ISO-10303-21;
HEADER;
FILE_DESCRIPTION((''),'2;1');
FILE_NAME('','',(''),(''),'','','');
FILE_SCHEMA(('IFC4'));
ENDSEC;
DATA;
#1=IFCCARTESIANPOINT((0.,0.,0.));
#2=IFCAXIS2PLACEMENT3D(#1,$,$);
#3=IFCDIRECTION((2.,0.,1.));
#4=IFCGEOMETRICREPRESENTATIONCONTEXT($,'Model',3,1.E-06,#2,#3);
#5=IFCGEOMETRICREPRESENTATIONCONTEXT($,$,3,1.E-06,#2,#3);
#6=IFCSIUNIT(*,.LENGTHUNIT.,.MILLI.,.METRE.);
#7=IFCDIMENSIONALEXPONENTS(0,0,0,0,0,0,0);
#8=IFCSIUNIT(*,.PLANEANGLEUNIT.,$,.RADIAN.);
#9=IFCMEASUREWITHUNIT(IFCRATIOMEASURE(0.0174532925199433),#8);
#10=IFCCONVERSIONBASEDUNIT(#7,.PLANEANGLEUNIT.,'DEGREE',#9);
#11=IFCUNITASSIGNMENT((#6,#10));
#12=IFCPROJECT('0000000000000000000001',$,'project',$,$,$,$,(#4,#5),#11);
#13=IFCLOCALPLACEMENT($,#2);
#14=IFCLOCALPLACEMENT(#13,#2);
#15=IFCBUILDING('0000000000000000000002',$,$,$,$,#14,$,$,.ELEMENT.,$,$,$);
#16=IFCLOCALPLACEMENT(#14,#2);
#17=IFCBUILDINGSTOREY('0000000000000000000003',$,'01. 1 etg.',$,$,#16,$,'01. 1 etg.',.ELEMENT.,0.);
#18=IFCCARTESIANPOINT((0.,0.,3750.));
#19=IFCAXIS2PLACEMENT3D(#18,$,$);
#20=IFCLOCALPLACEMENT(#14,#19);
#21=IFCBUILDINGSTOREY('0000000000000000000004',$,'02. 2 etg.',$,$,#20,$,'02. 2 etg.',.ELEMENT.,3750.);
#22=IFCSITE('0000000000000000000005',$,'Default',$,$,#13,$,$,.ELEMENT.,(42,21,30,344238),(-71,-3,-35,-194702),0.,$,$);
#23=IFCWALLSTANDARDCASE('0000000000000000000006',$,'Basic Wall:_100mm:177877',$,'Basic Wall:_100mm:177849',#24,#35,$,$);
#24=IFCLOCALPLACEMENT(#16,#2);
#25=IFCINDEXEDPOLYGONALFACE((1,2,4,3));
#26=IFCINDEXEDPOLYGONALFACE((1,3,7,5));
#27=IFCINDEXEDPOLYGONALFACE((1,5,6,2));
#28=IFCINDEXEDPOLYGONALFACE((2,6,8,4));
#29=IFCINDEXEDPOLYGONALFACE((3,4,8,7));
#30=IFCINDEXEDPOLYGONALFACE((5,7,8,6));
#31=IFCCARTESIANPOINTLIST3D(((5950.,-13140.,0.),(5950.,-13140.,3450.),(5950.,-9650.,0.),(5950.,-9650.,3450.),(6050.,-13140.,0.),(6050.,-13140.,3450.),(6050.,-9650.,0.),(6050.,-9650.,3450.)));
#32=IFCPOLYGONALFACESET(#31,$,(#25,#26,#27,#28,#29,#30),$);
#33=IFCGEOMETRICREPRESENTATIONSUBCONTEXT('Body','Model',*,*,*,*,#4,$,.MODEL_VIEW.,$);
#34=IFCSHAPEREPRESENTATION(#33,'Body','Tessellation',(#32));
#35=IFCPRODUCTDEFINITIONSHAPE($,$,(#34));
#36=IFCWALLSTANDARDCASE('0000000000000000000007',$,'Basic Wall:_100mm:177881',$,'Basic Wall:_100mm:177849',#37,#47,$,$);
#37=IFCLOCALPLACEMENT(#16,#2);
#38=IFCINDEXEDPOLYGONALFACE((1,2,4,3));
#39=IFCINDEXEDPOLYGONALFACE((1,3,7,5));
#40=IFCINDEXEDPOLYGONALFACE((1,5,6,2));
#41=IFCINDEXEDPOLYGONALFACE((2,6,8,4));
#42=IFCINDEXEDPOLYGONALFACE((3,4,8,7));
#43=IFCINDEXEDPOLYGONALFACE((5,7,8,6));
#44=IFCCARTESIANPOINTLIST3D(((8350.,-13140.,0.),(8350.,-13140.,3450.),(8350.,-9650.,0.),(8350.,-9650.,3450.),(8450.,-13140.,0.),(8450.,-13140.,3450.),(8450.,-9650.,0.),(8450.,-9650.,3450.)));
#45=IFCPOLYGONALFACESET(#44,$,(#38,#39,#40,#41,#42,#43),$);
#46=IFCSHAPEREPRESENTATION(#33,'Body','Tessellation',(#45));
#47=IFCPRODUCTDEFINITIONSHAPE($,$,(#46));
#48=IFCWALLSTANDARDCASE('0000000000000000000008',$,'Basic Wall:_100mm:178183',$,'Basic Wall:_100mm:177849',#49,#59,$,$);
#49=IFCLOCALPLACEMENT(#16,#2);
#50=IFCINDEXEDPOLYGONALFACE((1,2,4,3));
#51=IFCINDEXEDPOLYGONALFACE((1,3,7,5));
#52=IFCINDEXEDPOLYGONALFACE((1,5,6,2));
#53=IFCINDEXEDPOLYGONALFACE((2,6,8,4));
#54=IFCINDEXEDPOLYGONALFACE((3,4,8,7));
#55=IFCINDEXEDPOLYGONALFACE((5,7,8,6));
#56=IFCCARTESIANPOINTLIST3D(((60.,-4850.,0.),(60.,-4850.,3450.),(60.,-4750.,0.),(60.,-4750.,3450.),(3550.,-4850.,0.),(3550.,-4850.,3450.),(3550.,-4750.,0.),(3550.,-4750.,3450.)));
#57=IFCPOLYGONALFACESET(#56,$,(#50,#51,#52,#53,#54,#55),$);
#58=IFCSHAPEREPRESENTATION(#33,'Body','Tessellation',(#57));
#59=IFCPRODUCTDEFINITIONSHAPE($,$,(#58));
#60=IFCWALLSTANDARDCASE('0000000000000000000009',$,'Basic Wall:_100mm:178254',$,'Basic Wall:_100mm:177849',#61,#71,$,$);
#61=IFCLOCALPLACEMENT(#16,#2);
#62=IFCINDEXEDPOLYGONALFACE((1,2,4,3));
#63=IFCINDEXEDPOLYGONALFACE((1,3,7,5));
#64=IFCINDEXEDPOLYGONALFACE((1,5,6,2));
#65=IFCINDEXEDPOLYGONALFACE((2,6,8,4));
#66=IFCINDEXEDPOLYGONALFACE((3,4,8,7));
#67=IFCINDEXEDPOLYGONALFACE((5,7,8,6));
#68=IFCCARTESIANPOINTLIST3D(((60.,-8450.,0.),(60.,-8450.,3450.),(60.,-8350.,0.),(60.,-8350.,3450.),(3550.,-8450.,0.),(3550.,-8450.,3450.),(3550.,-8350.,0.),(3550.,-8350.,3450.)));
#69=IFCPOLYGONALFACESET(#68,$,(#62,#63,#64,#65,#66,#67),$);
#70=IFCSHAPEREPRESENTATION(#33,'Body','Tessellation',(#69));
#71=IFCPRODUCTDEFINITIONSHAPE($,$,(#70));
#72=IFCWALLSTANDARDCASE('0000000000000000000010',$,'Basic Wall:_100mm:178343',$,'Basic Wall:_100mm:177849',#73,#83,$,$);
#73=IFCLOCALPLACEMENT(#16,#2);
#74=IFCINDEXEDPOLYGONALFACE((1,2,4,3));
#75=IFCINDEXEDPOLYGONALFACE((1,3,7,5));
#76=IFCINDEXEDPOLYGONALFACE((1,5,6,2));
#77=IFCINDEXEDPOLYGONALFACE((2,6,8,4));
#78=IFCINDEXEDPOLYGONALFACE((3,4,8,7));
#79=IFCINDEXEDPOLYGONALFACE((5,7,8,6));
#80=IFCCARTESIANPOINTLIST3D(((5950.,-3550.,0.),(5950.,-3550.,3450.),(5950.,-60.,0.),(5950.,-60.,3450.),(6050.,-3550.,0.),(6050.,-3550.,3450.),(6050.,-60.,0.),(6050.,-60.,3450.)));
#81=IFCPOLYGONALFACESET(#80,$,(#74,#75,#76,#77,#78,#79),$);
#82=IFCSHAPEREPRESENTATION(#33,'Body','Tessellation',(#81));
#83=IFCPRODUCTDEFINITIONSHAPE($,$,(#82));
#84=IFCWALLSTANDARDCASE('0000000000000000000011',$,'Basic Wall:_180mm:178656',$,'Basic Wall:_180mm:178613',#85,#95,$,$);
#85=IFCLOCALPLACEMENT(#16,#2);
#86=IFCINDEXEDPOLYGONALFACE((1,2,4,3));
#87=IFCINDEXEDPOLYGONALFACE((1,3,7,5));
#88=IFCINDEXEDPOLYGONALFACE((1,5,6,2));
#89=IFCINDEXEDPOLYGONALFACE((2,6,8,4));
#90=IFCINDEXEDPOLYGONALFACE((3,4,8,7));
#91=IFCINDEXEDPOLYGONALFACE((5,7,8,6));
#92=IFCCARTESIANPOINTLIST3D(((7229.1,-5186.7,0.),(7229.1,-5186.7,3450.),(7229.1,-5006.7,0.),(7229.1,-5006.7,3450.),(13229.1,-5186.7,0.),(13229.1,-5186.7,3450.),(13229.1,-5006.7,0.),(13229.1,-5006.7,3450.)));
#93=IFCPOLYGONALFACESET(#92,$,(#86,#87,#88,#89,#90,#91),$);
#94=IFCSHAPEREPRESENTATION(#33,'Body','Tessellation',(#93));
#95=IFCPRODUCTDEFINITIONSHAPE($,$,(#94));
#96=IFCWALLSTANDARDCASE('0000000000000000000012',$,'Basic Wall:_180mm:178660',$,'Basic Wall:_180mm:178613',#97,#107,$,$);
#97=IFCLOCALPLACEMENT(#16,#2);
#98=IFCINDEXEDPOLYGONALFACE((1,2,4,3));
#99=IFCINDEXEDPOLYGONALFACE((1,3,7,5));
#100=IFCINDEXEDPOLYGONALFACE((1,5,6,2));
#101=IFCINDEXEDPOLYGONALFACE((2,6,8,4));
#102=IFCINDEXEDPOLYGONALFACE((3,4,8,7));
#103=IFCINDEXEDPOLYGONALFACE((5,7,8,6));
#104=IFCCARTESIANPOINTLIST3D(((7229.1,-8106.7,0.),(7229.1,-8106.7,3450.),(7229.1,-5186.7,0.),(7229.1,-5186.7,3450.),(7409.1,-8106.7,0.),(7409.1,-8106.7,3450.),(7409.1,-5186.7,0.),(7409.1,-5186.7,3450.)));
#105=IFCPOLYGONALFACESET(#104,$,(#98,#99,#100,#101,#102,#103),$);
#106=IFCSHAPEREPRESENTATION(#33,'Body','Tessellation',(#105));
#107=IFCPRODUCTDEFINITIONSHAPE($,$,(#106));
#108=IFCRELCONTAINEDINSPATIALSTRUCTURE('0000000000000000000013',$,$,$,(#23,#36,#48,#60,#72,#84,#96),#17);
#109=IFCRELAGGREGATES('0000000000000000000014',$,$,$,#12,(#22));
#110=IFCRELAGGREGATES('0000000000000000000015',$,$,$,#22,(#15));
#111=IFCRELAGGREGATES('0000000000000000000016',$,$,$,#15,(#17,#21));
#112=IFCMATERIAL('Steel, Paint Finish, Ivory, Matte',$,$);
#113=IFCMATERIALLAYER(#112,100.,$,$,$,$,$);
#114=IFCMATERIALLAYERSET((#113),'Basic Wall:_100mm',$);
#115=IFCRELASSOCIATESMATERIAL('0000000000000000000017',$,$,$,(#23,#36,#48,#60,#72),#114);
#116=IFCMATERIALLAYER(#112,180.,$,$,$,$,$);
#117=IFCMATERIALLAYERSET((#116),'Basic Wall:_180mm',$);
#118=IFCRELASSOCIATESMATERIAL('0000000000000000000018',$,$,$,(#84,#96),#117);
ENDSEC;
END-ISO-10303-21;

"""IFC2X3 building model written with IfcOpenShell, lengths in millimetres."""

from ifc_helpers import new_model, entity, si_unit, converted_unit, direction, frame, frame_2d, origin, place, context, subcontext, project, spatial, polyline, rectangle, extrude, clip, bounded_halfspace, material, layer, layer_set, layer_usage, element, save


model = new_model("IFC2X3")

# Units and contexts
model_context = context("Model", 3, precision=1e-06, world=origin(), true_north=direction((2.0, 0.0, 1.0)))
context_of_model = context(None, 3, precision=1e-06, world=origin(), true_north=direction((2.0, 0.0, 1.0)))
body_context = subcontext(model_context, "Body", "Model", "MODEL_VIEW")
ifc_project = project(units=[si_unit("LENGTHUNIT", "METRE", prefix="MILLI"), converted_unit("PLANEANGLEUNIT", "DEGREE", entity("IfcRatioMeasure", 0.0174532925199433), si_unit("PLANEANGLEUNIT", "RADIAN"), dimensions=[0, 0, 0, 0, 0, 0, 0])], contexts=[model_context, context_of_model])

# Site, building, storey
site_placement = place(None, origin())
site = spatial("IfcSite", under=ifc_project, at=site_placement, Name="Default", CompositionType="ELEMENT", RefLatitude=(42, 21, 30, 344238), RefLongitude=(-71, -3, -35, -194702), RefElevation=0.0)
building_placement = place(site_placement, origin())
building = spatial("IfcBuilding", under=site, at=building_placement, CompositionType="ELEMENT")
storey_1_placement = place(building_placement, origin())
storey_1 = spatial("IfcBuildingStorey", under=building, at=storey_1_placement, Name="01. 1 etg.", LongName="01. 1 etg.", CompositionType="ELEMENT", Elevation=0.0)

# Shared definitions
ifc_material_1 = material(Name="Steel, Paint Finish, Ivory, Matte")
ifc_layer_1 = layer(ifc_material_1, 100.0)
ifc_layer_set_1 = layer_set([ifc_layer_1], Name="Basic Wall:_100mm")

# Walls
ifc_layer_usage_1 = layer_usage(ifc_layer_set_1, "AXIS2", "NEGATIVE", 50.0)
wall_1_placement = place(storey_1_placement, frame((6000.0, -13140.0, 0.0), z_axis=(0.0, 0.0, 1.0), x_axis=(0.0, 1.0, 0.0)))
element("IfcWallStandardCase", 1, at=wall_1_placement, inside=storey_1, material=ifc_layer_usage_1, Name="Basic Wall:_100mm:177877", ObjectType="Basic Wall:_100mm:177849", context=body_context, shape_type="Clipping", body=[
    clip(extrude(rectangle(XDim=3490.0, YDim=100.0, at=frame_2d((1745.0, 0.0), x_axis=(-1.0, 0.0))), origin(), (0.0, 0.0, 1.0), 3450.0), bounded_halfspace(frame((0.0, -50.0, 3450.0), z_axis=(0.0, 0.0, -1.0), x_axis=(-1.0, 0.0, 0.0)), True, frame((0.0, -50.0, 3450.0)), polyline([(0.0, 0.0), (3490.0, 0.0), (3490.0, 100.0), (0.0, 100.0), (0.0, 0.0)]))),
])
ifc_layer_usage_2 = layer_usage(ifc_layer_set_1, "AXIS2", "NEGATIVE", 50.0)
wall_2_placement = place(storey_1_placement, frame((8400.0, -13140.0, 0.0), z_axis=(0.0, 0.0, 1.0), x_axis=(0.0, 1.0, 0.0)))
element("IfcWallStandardCase", 2, at=wall_2_placement, inside=storey_1, material=ifc_layer_usage_2, Name="Basic Wall:_100mm:177881", ObjectType="Basic Wall:_100mm:177849", context=body_context, shape_type="Clipping", body=[
    clip(extrude(rectangle(XDim=3490.0, YDim=100.0, at=frame_2d((1745.0, 0.0), x_axis=(-1.0, 0.0))), origin(), (0.0, 0.0, 1.0), 3450.0), bounded_halfspace(frame((0.0, -50.0, 3450.0), z_axis=(0.0, 0.0, -1.0), x_axis=(-1.0, 0.0, 0.0)), True, frame((0.0, -50.0, 3450.0)), polyline([(0.0, 0.0), (3490.0, 0.0), (3490.0, 100.0), (0.0, 100.0), (0.0, 0.0)]))),
])
ifc_layer_usage_3 = layer_usage(ifc_layer_set_1, "AXIS2", "NEGATIVE", 50.0)
wall_3_placement = place(storey_1_placement, frame((3550.0, -4800.0, 0.0), z_axis=(0.0, 0.0, 1.0), x_axis=(-1.0, 0.0, 0.0)))
element("IfcWallStandardCase", 3, at=wall_3_placement, inside=storey_1, material=ifc_layer_usage_3, Name="Basic Wall:_100mm:178183", ObjectType="Basic Wall:_100mm:177849", context=body_context, shape_type="Clipping", body=[
    clip(extrude(rectangle(XDim=3490.0, YDim=100.0, at=frame_2d((1745.0, 0.0), x_axis=(-1.0, 0.0))), origin(), (0.0, 0.0, 1.0), 3450.0), bounded_halfspace(frame((0.0, -50.0, 3450.0), z_axis=(0.0, 0.0, -1.0), x_axis=(0.0, 1.0, 0.0)), True, frame((0.0, -50.0, 3450.0)), polyline([(0.0, 0.0), (3490.0, 0.0), (3490.0, 100.0), (0.0, 100.0), (0.0, 0.0)]))),
])
ifc_layer_usage_4 = layer_usage(ifc_layer_set_1, "AXIS2", "NEGATIVE", 50.0)
wall_4_placement = place(storey_1_placement, frame((3550.0, -8400.0, 0.0), z_axis=(0.0, 0.0, 1.0), x_axis=(-1.0, 0.0, 0.0)))
element("IfcWallStandardCase", 4, at=wall_4_placement, inside=storey_1, material=ifc_layer_usage_4, Name="Basic Wall:_100mm:178254", ObjectType="Basic Wall:_100mm:177849", context=body_context, shape_type="Clipping", body=[
    clip(extrude(rectangle(XDim=3490.0, YDim=100.0, at=frame_2d((1745.0, 0.0), x_axis=(-1.0, 0.0))), origin(), (0.0, 0.0, 1.0), 3450.0), bounded_halfspace(frame((0.0, -50.0, 3450.0), z_axis=(0.0, 0.0, -1.0), x_axis=(0.0, 1.0, 0.0)), True, frame((0.0, -50.0, 3450.0)), polyline([(0.0, 0.0), (3490.0, 0.0), (3490.0, 100.0), (0.0, 100.0), (0.0, 0.0)]))),
])
ifc_layer_usage_5 = layer_usage(ifc_layer_set_1, "AXIS2", "NEGATIVE", 50.0)
wall_5_placement = place(storey_1_placement, frame((6000.0, -3550.0, 0.0), z_axis=(0.0, 0.0, 1.0), x_axis=(0.0, 1.0, 0.0)))
element("IfcWallStandardCase", 5, at=wall_5_placement, inside=storey_1, material=ifc_layer_usage_5, Name="Basic Wall:_100mm:178343", ObjectType="Basic Wall:_100mm:177849", context=body_context, shape_type="Clipping", body=[
    clip(extrude(rectangle(XDim=3490.0, YDim=100.0, at=frame_2d((1745.0, 0.0), x_axis=(-1.0, 0.0))), origin(), (0.0, 0.0, 1.0), 3450.0), bounded_halfspace(frame((0.0, -50.0, 3450.0), z_axis=(0.0, 0.0, -1.0), x_axis=(-1.0, 0.0, 0.0)), True, frame((0.0, -50.0, 3450.0)), polyline([(0.0, 0.0), (3490.0, 0.0), (3490.0, 100.0), (0.0, 100.0), (0.0, 0.0)]))),
])
ifc_layer_2 = layer(ifc_material_1, 180.0)
ifc_layer_set_2 = layer_set([ifc_layer_2], Name="Basic Wall:_180mm")
ifc_layer_usage_6 = layer_usage(ifc_layer_set_2, "AXIS2", "NEGATIVE", 90.0)
wall_6_placement = place(storey_1_placement, frame((7229.1, -5096.7, 0.0)))
element("IfcWallStandardCase", 6, at=wall_6_placement, inside=storey_1, material=ifc_layer_usage_6, Name="Basic Wall:_180mm:178656", ObjectType="Basic Wall:_180mm:178613", context=body_context, shape_type="Clipping", body=[
    clip(extrude(rectangle(XDim=6000.0, YDim=180.0, at=frame_2d((3000.0, 0.0), x_axis=(-1.0, 0.0))), origin(), (0.0, 0.0, 1.0), 3450.0), bounded_halfspace(frame((0.0, -90.0, 3450.0), z_axis=(0.0, 0.0, -1.0), x_axis=(0.0, -1.0, 0.0)), True, frame((0.0, -90.0, 3450.0)), polyline([(0.0, 0.0), (180.0, 0.0), (2400.0, 0.0), (2500.0, 0.0), (4022.0, 0.0), (4122.0, 0.0), (5820.0, 0.0), (6000.0, 0.0), (6000.0, 180.0), (0.0, 180.0), (0.0, 0.0)]))),
])
ifc_layer_usage_7 = layer_usage(ifc_layer_set_2, "AXIS2", "NEGATIVE", 90.0)
wall_7_placement = place(storey_1_placement, frame((7319.1, -8106.7, 0.0), z_axis=(0.0, 0.0, 1.0), x_axis=(0.0, 1.0, 0.0)))
element("IfcWallStandardCase", 7, at=wall_7_placement, inside=storey_1, material=ifc_layer_usage_7, Name="Basic Wall:_180mm:178660", ObjectType="Basic Wall:_180mm:178613", context=body_context, shape_type="Clipping", body=[
    clip(extrude(rectangle(XDim=2920.0, YDim=180.0, at=frame_2d((1460.0, 0.0), x_axis=(-1.0, 0.0))), origin(), (0.0, 0.0, 1.0), 3450.0), bounded_halfspace(frame((0.0, -90.0, 3450.0), z_axis=(0.0, 0.0, -1.0), x_axis=(-1.0, 0.0, 0.0)), True, frame((0.0, -90.0, 3450.0)), polyline([(0.0, 0.0), (180.0, 0.0), (2920.0, 0.0), (2920.0, 180.0), (0.0, 180.0), (0.0, 0.0)]))),
])

# Shared definitions
storey_2_placement = place(building_placement, frame((0.0, 0.0, 3750.0)))
storey_2 = spatial("IfcBuildingStorey", under=building, at=storey_2_placement, Name="02. 2 etg.", LongName="02. 2 etg.", CompositionType="ELEMENT", Elevation=3750.0)

save(model, "model.ifc")
